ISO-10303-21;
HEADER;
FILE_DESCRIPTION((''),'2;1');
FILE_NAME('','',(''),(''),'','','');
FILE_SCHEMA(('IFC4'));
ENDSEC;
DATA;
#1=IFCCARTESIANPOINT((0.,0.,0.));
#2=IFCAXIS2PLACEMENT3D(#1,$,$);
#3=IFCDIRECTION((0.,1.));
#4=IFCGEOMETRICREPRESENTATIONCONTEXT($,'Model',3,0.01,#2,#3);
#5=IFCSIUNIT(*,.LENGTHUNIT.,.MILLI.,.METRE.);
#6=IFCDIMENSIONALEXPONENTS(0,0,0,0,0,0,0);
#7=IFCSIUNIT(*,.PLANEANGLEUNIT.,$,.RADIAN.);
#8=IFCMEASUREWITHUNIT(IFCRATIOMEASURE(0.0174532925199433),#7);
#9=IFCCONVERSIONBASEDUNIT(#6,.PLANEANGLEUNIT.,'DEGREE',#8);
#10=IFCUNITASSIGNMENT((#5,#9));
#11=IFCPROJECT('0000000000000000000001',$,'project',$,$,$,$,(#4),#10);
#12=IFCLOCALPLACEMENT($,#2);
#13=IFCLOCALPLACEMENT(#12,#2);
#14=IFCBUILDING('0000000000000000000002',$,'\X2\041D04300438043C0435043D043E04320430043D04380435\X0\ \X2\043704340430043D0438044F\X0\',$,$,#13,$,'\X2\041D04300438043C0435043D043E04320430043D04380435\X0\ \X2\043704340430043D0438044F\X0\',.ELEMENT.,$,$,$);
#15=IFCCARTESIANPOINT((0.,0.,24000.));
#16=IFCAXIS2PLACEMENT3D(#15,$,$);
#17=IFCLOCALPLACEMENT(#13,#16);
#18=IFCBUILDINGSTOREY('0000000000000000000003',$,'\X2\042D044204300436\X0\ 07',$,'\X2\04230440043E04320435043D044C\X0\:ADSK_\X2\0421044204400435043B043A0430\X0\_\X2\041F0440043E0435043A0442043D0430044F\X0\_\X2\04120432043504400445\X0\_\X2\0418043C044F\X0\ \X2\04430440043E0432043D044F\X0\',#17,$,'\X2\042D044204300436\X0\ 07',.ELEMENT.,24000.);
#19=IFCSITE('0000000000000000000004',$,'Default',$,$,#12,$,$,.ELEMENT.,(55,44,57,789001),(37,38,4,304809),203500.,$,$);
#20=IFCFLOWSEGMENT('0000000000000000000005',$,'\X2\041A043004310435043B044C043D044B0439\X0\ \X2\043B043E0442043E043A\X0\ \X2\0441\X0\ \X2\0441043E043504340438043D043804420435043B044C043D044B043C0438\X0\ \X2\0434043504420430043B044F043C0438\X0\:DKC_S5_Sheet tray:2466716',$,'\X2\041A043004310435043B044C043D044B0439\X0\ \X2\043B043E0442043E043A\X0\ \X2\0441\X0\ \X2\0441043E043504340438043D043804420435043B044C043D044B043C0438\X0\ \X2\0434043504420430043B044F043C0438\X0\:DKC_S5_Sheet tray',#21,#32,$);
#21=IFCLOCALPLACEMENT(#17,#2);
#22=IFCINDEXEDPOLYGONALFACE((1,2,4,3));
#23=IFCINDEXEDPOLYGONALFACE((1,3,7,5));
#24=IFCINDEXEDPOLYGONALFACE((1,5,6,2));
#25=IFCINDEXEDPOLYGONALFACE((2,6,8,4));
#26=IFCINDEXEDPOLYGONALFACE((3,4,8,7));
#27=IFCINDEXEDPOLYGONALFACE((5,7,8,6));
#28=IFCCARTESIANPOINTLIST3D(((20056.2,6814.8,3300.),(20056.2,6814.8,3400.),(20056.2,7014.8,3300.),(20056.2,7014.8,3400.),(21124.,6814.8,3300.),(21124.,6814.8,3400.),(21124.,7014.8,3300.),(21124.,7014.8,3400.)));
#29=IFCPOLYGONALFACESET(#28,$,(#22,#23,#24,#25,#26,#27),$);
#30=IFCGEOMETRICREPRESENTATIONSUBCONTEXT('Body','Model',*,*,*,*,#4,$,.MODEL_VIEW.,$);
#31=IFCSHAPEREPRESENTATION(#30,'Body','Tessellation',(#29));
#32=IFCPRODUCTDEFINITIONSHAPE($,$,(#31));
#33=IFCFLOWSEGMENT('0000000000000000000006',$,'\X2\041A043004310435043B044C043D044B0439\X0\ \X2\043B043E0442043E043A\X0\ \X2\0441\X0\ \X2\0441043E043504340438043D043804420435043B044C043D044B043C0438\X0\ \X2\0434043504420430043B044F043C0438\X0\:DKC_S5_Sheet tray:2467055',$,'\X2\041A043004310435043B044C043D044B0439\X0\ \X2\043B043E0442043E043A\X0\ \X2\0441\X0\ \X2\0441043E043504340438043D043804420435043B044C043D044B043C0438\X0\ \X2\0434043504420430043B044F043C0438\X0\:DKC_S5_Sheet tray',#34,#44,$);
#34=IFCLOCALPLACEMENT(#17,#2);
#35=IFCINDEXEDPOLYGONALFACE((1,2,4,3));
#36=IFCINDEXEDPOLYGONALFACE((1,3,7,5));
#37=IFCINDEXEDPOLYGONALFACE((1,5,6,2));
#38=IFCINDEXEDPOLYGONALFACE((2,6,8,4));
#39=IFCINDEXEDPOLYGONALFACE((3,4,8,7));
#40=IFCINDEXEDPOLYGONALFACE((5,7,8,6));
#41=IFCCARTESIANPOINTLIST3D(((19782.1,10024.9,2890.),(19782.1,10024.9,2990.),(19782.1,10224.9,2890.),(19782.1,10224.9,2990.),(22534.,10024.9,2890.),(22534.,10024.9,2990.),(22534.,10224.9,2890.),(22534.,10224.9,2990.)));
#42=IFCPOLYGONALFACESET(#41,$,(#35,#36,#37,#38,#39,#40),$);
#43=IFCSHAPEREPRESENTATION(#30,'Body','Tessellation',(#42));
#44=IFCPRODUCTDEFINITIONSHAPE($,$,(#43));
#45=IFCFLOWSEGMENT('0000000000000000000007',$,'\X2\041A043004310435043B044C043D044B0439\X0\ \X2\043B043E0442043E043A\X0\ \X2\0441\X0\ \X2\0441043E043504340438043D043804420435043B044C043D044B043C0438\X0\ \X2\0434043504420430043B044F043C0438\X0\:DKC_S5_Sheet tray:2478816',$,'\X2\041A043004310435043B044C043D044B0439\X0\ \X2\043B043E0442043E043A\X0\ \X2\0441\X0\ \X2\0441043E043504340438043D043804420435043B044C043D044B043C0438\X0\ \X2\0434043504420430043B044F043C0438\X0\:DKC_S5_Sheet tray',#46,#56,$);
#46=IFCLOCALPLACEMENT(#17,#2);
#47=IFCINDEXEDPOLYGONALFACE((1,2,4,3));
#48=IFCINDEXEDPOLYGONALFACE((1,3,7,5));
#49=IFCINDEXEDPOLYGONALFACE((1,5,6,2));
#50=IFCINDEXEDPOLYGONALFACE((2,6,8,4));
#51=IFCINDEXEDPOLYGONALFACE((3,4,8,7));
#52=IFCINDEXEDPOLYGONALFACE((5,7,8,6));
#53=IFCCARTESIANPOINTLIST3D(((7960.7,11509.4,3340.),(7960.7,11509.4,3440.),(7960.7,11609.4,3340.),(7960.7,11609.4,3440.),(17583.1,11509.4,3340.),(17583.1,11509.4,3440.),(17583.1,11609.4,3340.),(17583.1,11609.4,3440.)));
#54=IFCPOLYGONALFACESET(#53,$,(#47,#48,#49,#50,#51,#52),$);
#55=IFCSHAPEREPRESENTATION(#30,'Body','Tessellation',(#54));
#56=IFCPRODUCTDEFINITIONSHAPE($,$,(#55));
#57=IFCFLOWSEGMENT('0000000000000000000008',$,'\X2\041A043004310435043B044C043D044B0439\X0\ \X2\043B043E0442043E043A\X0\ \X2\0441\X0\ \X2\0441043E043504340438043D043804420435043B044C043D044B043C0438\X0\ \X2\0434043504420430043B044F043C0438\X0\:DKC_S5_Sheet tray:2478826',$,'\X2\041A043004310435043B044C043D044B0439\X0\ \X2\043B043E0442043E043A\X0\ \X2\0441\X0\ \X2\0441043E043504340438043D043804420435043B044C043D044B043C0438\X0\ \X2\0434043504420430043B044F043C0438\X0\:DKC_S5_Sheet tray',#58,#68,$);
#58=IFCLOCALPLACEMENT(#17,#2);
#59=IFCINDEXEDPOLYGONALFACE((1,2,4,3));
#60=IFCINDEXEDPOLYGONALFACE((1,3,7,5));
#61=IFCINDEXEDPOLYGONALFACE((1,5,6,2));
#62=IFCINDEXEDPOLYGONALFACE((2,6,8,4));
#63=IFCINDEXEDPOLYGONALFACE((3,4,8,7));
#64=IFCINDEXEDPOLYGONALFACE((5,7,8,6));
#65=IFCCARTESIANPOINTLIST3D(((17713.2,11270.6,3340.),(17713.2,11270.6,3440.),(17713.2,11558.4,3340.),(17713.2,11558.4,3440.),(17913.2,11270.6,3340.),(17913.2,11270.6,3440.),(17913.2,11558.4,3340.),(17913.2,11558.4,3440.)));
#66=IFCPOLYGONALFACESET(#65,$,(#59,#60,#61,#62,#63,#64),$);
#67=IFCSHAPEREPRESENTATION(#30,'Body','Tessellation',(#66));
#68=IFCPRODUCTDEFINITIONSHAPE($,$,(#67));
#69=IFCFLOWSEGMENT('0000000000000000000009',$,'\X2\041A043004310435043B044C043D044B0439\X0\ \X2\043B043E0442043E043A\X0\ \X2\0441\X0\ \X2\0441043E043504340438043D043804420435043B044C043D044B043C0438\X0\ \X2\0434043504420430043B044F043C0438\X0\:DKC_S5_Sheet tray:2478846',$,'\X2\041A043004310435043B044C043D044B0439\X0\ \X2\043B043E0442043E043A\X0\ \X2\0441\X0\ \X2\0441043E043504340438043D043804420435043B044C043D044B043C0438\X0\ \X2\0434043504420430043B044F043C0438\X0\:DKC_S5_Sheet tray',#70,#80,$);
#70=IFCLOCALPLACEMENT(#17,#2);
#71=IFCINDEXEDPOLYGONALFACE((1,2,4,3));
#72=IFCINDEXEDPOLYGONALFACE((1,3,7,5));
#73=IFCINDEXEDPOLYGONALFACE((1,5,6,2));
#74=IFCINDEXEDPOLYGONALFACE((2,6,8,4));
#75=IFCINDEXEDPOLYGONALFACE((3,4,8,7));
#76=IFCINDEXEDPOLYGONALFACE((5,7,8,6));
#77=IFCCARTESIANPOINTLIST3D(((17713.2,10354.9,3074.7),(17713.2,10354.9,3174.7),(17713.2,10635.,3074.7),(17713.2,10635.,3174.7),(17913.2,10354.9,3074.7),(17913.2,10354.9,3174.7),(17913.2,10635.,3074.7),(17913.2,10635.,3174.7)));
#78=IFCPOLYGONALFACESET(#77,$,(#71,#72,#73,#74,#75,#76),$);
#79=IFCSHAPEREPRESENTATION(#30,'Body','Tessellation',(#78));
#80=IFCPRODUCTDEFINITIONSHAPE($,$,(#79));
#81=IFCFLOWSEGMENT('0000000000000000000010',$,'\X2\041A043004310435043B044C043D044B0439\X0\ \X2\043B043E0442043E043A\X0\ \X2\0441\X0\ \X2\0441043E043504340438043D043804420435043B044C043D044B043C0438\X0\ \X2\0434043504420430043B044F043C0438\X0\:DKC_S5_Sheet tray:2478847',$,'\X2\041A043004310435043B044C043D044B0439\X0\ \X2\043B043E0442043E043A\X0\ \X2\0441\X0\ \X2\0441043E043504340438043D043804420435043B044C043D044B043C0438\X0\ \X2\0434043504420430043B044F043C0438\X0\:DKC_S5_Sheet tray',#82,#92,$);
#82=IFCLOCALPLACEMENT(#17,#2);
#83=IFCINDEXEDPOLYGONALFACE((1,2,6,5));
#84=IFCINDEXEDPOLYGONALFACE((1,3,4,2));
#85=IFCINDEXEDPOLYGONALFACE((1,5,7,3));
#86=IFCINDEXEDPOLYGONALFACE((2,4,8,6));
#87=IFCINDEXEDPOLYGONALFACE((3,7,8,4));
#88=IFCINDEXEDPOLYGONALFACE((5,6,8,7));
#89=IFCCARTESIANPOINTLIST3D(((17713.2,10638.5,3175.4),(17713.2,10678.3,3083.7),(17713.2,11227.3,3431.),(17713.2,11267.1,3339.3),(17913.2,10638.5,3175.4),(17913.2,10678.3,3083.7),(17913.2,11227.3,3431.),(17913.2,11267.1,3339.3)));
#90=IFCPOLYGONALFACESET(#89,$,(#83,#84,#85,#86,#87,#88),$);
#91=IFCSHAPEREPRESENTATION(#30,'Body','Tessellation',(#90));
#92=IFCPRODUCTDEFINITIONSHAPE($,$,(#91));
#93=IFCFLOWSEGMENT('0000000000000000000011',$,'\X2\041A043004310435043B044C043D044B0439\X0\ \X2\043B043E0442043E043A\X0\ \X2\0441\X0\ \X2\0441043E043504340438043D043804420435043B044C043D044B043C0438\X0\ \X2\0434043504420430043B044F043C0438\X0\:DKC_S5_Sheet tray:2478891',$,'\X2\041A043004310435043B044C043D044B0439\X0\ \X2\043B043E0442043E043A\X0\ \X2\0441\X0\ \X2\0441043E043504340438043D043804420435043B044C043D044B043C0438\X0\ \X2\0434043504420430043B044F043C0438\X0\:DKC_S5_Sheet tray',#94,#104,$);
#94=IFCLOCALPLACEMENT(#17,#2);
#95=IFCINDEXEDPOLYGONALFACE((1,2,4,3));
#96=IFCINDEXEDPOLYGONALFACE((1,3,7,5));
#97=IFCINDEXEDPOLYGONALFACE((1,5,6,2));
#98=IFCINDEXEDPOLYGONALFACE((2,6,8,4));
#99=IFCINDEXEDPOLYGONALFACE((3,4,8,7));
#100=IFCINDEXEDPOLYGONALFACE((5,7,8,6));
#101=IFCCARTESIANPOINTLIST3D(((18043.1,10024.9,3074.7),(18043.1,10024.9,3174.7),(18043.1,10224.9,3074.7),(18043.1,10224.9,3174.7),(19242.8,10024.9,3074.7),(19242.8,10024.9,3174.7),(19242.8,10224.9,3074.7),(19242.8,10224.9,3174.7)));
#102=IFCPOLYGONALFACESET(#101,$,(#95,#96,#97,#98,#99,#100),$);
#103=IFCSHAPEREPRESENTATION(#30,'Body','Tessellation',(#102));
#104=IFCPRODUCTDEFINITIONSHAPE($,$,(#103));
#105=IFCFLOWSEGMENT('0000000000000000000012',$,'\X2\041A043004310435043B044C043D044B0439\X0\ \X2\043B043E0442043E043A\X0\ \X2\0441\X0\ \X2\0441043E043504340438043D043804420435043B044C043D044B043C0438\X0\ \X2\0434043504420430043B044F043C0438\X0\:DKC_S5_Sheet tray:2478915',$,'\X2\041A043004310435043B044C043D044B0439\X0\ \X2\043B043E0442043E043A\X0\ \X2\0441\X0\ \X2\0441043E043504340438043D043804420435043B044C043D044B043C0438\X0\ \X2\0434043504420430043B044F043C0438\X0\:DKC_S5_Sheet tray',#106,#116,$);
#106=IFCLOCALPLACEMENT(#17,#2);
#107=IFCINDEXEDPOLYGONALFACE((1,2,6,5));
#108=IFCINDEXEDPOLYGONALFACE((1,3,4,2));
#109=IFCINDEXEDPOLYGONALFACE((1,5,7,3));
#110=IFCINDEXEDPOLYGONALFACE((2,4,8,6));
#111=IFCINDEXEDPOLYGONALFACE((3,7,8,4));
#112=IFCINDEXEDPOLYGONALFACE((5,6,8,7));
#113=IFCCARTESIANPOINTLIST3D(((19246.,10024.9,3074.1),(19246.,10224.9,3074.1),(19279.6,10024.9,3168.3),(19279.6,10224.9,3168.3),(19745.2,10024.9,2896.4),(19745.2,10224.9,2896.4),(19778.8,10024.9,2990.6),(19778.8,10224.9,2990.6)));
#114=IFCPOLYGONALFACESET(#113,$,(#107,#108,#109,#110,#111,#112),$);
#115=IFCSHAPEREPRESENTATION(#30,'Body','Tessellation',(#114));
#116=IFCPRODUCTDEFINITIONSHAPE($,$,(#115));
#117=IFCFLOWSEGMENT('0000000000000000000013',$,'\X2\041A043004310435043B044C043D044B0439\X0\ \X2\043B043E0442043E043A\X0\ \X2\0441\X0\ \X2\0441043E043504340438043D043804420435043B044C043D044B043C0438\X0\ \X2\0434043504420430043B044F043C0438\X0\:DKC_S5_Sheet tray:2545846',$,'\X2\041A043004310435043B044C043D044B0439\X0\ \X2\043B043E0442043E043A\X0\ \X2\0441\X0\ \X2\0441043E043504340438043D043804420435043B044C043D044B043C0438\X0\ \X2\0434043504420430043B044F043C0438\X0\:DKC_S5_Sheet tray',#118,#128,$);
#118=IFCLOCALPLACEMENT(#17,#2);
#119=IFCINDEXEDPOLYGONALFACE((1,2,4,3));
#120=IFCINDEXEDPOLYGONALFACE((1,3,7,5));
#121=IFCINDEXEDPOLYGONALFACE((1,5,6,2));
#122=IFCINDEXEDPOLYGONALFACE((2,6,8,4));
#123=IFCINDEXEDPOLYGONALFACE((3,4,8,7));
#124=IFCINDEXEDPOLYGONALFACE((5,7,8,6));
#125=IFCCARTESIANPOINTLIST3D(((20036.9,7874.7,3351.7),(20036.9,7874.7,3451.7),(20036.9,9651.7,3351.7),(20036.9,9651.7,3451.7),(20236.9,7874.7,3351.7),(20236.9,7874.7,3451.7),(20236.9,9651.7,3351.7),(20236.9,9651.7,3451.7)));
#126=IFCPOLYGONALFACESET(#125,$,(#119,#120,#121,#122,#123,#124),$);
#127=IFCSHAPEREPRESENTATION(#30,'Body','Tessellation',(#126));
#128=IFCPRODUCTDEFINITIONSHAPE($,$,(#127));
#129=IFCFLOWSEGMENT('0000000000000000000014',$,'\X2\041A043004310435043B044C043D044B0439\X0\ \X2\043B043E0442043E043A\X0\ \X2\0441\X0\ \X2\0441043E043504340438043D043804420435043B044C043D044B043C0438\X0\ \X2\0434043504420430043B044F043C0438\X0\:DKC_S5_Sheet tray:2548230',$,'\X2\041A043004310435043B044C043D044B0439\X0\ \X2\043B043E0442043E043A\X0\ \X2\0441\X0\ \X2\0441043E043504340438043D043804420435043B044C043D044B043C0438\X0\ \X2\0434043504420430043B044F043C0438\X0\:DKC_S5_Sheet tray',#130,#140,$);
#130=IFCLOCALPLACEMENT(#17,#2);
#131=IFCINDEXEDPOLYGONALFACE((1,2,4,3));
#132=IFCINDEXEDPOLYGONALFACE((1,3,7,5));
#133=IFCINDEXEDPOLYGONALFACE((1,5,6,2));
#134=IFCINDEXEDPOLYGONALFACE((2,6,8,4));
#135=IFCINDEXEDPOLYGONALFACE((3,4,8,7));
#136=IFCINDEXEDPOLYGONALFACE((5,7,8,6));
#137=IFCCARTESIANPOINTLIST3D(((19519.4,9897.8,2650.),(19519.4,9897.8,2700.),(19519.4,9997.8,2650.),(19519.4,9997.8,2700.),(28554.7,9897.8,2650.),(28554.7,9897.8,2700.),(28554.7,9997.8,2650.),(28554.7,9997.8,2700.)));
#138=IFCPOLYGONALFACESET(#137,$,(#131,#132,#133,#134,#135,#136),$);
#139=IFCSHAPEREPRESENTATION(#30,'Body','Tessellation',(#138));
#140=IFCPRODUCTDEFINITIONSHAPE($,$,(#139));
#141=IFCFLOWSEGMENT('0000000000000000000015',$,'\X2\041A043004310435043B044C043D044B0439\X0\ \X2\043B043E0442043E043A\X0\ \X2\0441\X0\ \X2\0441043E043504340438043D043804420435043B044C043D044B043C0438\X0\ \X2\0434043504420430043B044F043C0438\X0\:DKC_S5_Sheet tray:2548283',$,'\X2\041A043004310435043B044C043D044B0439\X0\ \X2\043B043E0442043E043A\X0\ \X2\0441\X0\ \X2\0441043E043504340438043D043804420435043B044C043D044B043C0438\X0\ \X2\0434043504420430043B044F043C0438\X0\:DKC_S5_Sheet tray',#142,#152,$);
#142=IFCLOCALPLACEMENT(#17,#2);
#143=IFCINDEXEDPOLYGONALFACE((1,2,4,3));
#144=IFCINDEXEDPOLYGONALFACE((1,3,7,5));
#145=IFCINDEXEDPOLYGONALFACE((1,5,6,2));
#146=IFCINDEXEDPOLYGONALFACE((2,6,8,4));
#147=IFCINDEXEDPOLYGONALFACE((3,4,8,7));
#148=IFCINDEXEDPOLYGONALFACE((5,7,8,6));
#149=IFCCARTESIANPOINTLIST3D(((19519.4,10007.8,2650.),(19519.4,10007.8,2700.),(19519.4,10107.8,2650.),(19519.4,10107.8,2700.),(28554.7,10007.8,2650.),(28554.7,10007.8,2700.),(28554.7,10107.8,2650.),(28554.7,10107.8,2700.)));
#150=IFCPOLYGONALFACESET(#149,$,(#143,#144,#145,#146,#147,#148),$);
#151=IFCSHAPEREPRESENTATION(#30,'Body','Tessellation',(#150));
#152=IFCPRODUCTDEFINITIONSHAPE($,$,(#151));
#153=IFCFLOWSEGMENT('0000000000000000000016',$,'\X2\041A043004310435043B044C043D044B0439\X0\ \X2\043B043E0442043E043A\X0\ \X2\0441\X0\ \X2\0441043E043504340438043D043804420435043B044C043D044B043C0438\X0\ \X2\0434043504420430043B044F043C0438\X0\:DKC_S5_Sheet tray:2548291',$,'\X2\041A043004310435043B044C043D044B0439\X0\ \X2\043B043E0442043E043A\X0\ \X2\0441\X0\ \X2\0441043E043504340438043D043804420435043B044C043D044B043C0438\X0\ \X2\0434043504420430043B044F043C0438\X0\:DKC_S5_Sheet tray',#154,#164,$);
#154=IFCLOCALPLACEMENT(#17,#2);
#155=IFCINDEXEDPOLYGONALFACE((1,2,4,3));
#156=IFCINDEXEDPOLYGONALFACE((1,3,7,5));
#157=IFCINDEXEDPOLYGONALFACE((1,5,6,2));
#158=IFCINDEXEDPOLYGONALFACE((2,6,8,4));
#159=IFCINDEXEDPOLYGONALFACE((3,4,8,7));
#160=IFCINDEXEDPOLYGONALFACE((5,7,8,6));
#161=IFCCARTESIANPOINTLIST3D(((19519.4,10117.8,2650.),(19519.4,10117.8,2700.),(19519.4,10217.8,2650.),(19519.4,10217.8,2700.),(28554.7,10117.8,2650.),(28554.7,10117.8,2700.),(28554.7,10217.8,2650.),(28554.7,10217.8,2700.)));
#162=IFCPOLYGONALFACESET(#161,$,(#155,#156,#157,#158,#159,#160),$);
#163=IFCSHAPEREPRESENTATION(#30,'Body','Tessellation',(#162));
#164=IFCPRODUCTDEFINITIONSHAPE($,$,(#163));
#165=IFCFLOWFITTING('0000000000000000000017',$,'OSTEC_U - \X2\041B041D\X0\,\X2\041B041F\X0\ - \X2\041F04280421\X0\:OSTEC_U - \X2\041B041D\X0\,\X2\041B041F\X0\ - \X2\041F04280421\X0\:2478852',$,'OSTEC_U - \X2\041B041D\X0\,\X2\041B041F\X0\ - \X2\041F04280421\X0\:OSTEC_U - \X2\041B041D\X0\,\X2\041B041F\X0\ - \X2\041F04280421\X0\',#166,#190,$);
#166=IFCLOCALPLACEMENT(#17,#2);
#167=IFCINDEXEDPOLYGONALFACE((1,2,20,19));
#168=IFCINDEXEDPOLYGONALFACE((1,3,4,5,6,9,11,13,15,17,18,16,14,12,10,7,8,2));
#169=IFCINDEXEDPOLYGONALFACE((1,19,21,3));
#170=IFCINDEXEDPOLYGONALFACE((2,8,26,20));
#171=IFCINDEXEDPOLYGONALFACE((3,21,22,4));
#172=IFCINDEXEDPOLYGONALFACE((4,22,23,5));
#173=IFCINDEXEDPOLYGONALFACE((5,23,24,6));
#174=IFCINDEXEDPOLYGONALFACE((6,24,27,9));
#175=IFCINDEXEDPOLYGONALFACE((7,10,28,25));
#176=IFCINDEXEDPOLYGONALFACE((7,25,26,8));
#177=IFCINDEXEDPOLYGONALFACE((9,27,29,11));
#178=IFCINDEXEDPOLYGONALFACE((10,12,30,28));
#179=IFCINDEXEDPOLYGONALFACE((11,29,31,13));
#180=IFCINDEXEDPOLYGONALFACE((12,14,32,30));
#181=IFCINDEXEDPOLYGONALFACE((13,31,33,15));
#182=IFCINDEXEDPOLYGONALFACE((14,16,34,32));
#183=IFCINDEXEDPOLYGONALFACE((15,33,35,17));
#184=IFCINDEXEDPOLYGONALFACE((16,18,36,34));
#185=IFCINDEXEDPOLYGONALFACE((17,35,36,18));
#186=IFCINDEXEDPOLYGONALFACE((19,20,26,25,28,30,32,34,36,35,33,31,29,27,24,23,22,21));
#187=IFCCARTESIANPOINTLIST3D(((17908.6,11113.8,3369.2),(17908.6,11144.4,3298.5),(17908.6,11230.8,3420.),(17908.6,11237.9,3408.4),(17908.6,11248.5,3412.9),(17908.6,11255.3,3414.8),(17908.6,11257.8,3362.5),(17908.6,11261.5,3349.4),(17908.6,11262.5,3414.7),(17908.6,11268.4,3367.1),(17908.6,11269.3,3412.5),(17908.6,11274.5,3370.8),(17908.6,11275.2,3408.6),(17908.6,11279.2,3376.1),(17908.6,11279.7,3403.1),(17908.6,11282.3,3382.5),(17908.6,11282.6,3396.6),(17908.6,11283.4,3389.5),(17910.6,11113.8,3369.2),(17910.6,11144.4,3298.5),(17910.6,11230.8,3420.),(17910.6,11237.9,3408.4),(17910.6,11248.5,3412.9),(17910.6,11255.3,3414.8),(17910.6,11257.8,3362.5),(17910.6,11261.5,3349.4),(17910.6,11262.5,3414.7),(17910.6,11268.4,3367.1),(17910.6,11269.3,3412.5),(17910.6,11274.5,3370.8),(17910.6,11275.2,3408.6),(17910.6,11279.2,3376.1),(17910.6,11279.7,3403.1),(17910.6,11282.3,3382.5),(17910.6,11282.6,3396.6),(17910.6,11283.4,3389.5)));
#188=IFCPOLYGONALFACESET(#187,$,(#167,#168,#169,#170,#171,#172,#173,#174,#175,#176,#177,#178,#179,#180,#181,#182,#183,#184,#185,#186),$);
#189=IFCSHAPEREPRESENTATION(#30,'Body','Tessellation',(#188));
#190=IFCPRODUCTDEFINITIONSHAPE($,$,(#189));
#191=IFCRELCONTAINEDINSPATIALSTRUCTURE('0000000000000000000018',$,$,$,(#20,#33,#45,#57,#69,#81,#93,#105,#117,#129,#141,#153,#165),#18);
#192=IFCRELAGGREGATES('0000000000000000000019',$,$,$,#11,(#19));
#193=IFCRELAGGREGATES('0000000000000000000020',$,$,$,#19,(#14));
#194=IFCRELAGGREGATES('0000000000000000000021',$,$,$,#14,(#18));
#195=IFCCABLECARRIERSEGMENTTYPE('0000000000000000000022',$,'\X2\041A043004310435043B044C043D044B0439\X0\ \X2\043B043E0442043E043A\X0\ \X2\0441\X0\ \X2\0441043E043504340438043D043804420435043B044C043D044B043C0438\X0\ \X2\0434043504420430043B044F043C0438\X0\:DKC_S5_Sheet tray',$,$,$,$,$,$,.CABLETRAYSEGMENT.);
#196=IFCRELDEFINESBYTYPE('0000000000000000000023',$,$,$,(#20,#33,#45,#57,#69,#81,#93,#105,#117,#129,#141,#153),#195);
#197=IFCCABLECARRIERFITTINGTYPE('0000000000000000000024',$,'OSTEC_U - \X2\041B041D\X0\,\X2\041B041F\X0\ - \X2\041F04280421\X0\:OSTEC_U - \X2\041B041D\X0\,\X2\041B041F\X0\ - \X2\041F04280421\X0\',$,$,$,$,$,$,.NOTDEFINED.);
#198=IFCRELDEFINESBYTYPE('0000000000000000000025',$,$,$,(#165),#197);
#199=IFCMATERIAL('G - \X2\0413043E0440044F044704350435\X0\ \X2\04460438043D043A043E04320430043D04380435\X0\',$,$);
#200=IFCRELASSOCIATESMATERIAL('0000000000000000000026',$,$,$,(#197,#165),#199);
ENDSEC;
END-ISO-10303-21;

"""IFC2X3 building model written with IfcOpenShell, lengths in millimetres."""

from ifc_helpers import new_model, entity, si_unit, converted_unit, direction, frame, frame_2d, origin, origin_2d_with_axis, place, context, subcontext, project, spatial, polyline, circle_curve, parameter, trimmed, segment, composite_curve, rectangle, outline, extrude, source, transform, mapped, material, type_object, type_shapes, element, save


model = new_model("IFC2X3")

# Units and contexts
model_context = context("Model", 3, precision=0.01, world=origin(), true_north=direction((0.0, 1.0)))
body_context = subcontext(model_context, "Body", "Model", "MODEL_VIEW")
ifc_project = project(units=[si_unit("LENGTHUNIT", "METRE", prefix="MILLI"), converted_unit("PLANEANGLEUNIT", "DEGREE", entity("IfcRatioMeasure", 0.0174532925199433), si_unit("PLANEANGLEUNIT", "RADIAN"), dimensions=[0, 0, 0, 0, 0, 0, 0])], contexts=[model_context])

# Site, building, storey
site_placement = place(None, origin())
site = spatial("IfcSite", under=ifc_project, at=site_placement, Name="Default", CompositionType="ELEMENT", RefLatitude=(55, 44, 57, 789001), RefLongitude=(37, 38, 4, 304809), RefElevation=203500.0)
building_placement = place(site_placement, origin())
building = spatial("IfcBuilding", under=site, at=building_placement, Name="Наименование здания", LongName="Наименование здания", CompositionType="ELEMENT")
storey_placement = place(building_placement, frame((0.0, 0.0, 24000.0)))
storey = spatial("IfcBuildingStorey", under=building, at=storey_placement, Name="Этаж 07", ObjectType="Уровень:ADSK_Стрелка_Проектная_Вверх_Имя уровня", LongName="Этаж 07", CompositionType="ELEMENT", Elevation=24000.0)

# Flow segments
cable_carrier_segment_type = type_object("IfcCableCarrierSegmentType", Name="Кабельный лоток с соединительными деталями:DKC_S5_Sheet tray", PredefinedType="CABLETRAYSEGMENT")
flow_segment_1_placement = place(storey_placement, frame((20056.2, 6814.8, 3300.0)))
element("IfcFlowSegment", 1, at=flow_segment_1_placement, inside=storey, type_object=cable_carrier_segment_type, Name="Кабельный лоток с соединительными деталями:DKC_S5_Sheet tray:2466716", ObjectType="Кабельный лоток с соединительными деталями:DKC_S5_Sheet tray", context=body_context, shape_type="SweptSolid", body=[
    extrude(rectangle(XDim=1067.7, YDim=200.0, at=origin_2d_with_axis()), frame((533.9, 100.0, 0.0)), (0.0, 0.0, 1.0), 100.0),
])
flow_segment_2_placement = place(storey_placement, frame((19782.1, 10024.9, 2890.0)))
element("IfcFlowSegment", 2, at=flow_segment_2_placement, inside=storey, type_object=cable_carrier_segment_type, Name="Кабельный лоток с соединительными деталями:DKC_S5_Sheet tray:2467055", ObjectType="Кабельный лоток с соединительными деталями:DKC_S5_Sheet tray", context=body_context, shape_type="SweptSolid", body=[
    extrude(rectangle(XDim=2751.9, YDim=200.0, at=origin_2d_with_axis()), frame((1376.0, 100.0, 0.0), z_axis=(0.0, 0.0, 1.0), x_axis=(-1.0, 0.0, 0.0)), (0.0, 0.0, 1.0), 100.0),
])
flow_segment_3_placement = place(storey_placement, frame((7960.6, 11509.4, 3340.0)))
element("IfcFlowSegment", 3, at=flow_segment_3_placement, inside=storey, type_object=cable_carrier_segment_type, Name="Кабельный лоток с соединительными деталями:DKC_S5_Sheet tray:2478816", ObjectType="Кабельный лоток с соединительными деталями:DKC_S5_Sheet tray", context=body_context, shape_type="SweptSolid", body=[
    extrude(rectangle(XDim=9622.5, YDim=100.0, at=origin_2d_with_axis()), frame((4811.2, 50.0, 0.0), z_axis=(0.0, 0.0, 1.0), x_axis=(-1.0, 0.0, 0.0)), (0.0, 0.0, 1.0), 100.0),
])
flow_segment_4_placement = place(storey_placement, frame((17713.2, 11270.6, 3340.0)))
element("IfcFlowSegment", 4, at=flow_segment_4_placement, inside=storey, type_object=cable_carrier_segment_type, Name="Кабельный лоток с соединительными деталями:DKC_S5_Sheet tray:2478826", ObjectType="Кабельный лоток с соединительными деталями:DKC_S5_Sheet tray", context=body_context, shape_type="SweptSolid", body=[
    extrude(rectangle(XDim=287.8, YDim=200.0, at=origin_2d_with_axis()), frame((100.0, 143.9, 0.0), z_axis=(0.0, 0.0, 1.0), x_axis=(0.0, -1.0, 0.0)), (0.0, 0.0, 1.0), 100.0),
])
flow_segment_5_placement = place(storey_placement, frame((17713.2, 10354.9, 3074.7)))
element("IfcFlowSegment", 5, at=flow_segment_5_placement, inside=storey, type_object=cable_carrier_segment_type, Name="Кабельный лоток с соединительными деталями:DKC_S5_Sheet tray:2478846", ObjectType="Кабельный лоток с соединительными деталями:DKC_S5_Sheet tray", context=body_context, shape_type="SweptSolid", body=[
    extrude(rectangle(XDim=280.1, YDim=200.0, at=origin_2d_with_axis()), frame((100.0, 140.0, 0.0), z_axis=(0.0, 0.0, 1.0), x_axis=(0.0, -1.0, 0.0)), (0.0, 0.0, 1.0), 100.0),
])
flow_segment_6_placement = place(storey_placement, frame((17713.2, 10638.5, 3083.7)))
element("IfcFlowSegment", 6, at=flow_segment_6_placement, inside=storey, type_object=cable_carrier_segment_type, Name="Кабельный лоток с соединительными деталями:DKC_S5_Sheet tray:2478847", ObjectType="Кабельный лоток с соединительными деталями:DKC_S5_Sheet tray", context=body_context, shape_type="SweptSolid", body=[
    extrude(rectangle(XDim=100.0, YDim=641.9, at=frame_2d((0.0, 0.0), x_axis=(0.0, 1.0))), frame((0.0, 314.3, 173.7), z_axis=(1.0, 0.0, 0.0), x_axis=(0.0, 0.917307, 0.398181)), (0.0, 0.0, 1.0), 200.0),
])
flow_segment_7_placement = place(storey_placement, frame((18043.2, 10024.9, 3074.7)))
element("IfcFlowSegment", 7, at=flow_segment_7_placement, inside=storey, type_object=cable_carrier_segment_type, Name="Кабельный лоток с соединительными деталями:DKC_S5_Sheet tray:2478891", ObjectType="Кабельный лоток с соединительными деталями:DKC_S5_Sheet tray", context=body_context, shape_type="SweptSolid", body=[
    extrude(rectangle(XDim=1199.6, YDim=200.0, at=origin_2d_with_axis()), frame((599.8, 100.0, 0.0)), (0.0, 0.0, 1.0), 100.0),
])
flow_segment_8_placement = place(storey_placement, frame((19246.0, 10024.9, 2896.4)))
element("IfcFlowSegment", 8, at=flow_segment_8_placement, inside=storey, type_object=cable_carrier_segment_type, Name="Кабельный лоток с соединительными деталями:DKC_S5_Sheet tray:2478915", ObjectType="Кабельный лоток с соединительными деталями:DKC_S5_Sheet tray", context=body_context, shape_type="SweptSolid", body=[
    extrude(rectangle(XDim=100.0, YDim=200.0, at=origin_2d_with_axis()), frame((16.8, 100.0, 224.9), z_axis=(0.942059, 0.0, -0.335447), x_axis=(0.335447, 0.0, 0.942059)), (0.0, 0.0, 1.0), 529.9),
])
flow_segment_9_placement = place(storey_placement, frame((20036.9, 7874.7, 3351.7)))
element("IfcFlowSegment", 9, at=flow_segment_9_placement, inside=storey, type_object=cable_carrier_segment_type, Name="Кабельный лоток с соединительными деталями:DKC_S5_Sheet tray:2545846", ObjectType="Кабельный лоток с соединительными деталями:DKC_S5_Sheet tray", context=body_context, shape_type="SweptSolid", body=[
    extrude(rectangle(XDim=1776.9, YDim=200.0, at=origin_2d_with_axis()), frame((100.0, 888.5, 0.0), z_axis=(0.0, 0.0, 1.0), x_axis=(0.0, 1.0, 0.0)), (0.0, 0.0, 1.0), 100.0),
])
flow_segment_10_placement = place(storey_placement, frame((19519.4, 9897.8, 2650.0)))
element("IfcFlowSegment", 10, at=flow_segment_10_placement, inside=storey, type_object=cable_carrier_segment_type, Name="Кабельный лоток с соединительными деталями:DKC_S5_Sheet tray:2548230", ObjectType="Кабельный лоток с соединительными деталями:DKC_S5_Sheet tray", context=body_context, shape_type="SweptSolid", body=[
    extrude(rectangle(XDim=9035.3, YDim=100.0, at=origin_2d_with_axis()), frame((4517.6, 50.0, 0.0)), (0.0, 0.0, 1.0), 50.0),
])
flow_segment_11_placement = place(storey_placement, frame((19519.4, 10007.8, 2650.0)))
element("IfcFlowSegment", 11, at=flow_segment_11_placement, inside=storey, type_object=cable_carrier_segment_type, Name="Кабельный лоток с соединительными деталями:DKC_S5_Sheet tray:2548283", ObjectType="Кабельный лоток с соединительными деталями:DKC_S5_Sheet tray", context=body_context, shape_type="SweptSolid", body=[
    extrude(rectangle(XDim=9035.3, YDim=100.0, at=origin_2d_with_axis()), frame((4517.6, 50.0, 0.0)), (0.0, 0.0, 1.0), 50.0),
])
flow_segment_12_placement = place(storey_placement, frame((19519.4, 10117.8, 2650.0)))
element("IfcFlowSegment", 12, at=flow_segment_12_placement, inside=storey, type_object=cable_carrier_segment_type, Name="Кабельный лоток с соединительными деталями:DKC_S5_Sheet tray:2548291", ObjectType="Кабельный лоток с соединительными деталями:DKC_S5_Sheet tray", context=body_context, shape_type="SweptSolid", body=[
    extrude(rectangle(XDim=9035.3, YDim=100.0, at=origin_2d_with_axis()), frame((4517.7, 50.0, 0.0)), (0.0, 0.0, 1.0), 50.0),
])

# Flow fitting
ifc_material = material(Name="G - Горячее цинкование")
cable_carrier_fitting_type_1 = type_object("IfcCableCarrierFittingType", Name="OSTEC_U - ЛН,ЛП - ПШС:OSTEC_U - ЛН,ЛП - ПШС", PredefinedType="NOTDEFINED", material=ifc_material)
shared_shape_1 = source(origin(), body_context, "Body", "SweptSolid", [
    extrude(outline(composite_curve([segment(trimmed(circle_curve(frame_2d((-41.5, 0.0), x_axis=(1.0, 0.0)), 25.0), [parameter(90.0)], [parameter(270.0)], True, "PARAMETER"), True, "CONTINUOUS"), segment(polyline([(-41.5, -25.0), (-30.0, -25.0)]), True, "CONTINUOUS"), segment(polyline([(-30.0, -25.0), (-28.1, -38.5)]), True, "CONTINUOUS"), segment(polyline([(-28.1, -38.5), (99.5, -38.5)]), True, "CONTINUOUS"), segment(polyline([(99.5, -38.5), (99.5, 38.5)]), True, "CONTINUOUS"), segment(polyline([(99.5, 38.5), (-28.1, 38.5)]), True, "CONTINUOUS"), segment(polyline([(-28.1, 38.5), (-30.0, 25.0)]), True, "CONTINUOUS"), segment(polyline([(-30.0, 25.0), (-41.5, 25.0)]), True, "CONTINUOUS")], self_intersect=False)), frame((41.5, 0.0, 0.0), z_axis=(0.0, 0.0, -1.0), x_axis=(1.0, 0.0, 0.0)), (0.0, 0.0, -1.0), 2.0),
])
type_shapes(cable_carrier_fitting_type_1, [shared_shape_1])
flow_fitting_1_placement = place(storey_placement, frame((17908.6, 11258.4, 3390.0), z_axis=(1.0, 0.0, 0.0), x_axis=(0.0, -0.917307, -0.398181)))
element("IfcFlowFitting", 13, at=flow_fitting_1_placement, inside=storey, type_object=cable_carrier_fitting_type_1, material=ifc_material, Name="OSTEC_U - ЛН,ЛП - ПШС:OSTEC_U - ЛН,ЛП - ПШС:2478852", ObjectType="OSTEC_U - ЛН,ЛП - ПШС:OSTEC_U - ЛН,ЛП - ПШС", context=body_context, shape_type="MappedRepresentation", body=[
    mapped(shared_shape_1, transform((0.0, 0.0, 0.0), scale=1.0)),
])

save(model, "model.ifc")
